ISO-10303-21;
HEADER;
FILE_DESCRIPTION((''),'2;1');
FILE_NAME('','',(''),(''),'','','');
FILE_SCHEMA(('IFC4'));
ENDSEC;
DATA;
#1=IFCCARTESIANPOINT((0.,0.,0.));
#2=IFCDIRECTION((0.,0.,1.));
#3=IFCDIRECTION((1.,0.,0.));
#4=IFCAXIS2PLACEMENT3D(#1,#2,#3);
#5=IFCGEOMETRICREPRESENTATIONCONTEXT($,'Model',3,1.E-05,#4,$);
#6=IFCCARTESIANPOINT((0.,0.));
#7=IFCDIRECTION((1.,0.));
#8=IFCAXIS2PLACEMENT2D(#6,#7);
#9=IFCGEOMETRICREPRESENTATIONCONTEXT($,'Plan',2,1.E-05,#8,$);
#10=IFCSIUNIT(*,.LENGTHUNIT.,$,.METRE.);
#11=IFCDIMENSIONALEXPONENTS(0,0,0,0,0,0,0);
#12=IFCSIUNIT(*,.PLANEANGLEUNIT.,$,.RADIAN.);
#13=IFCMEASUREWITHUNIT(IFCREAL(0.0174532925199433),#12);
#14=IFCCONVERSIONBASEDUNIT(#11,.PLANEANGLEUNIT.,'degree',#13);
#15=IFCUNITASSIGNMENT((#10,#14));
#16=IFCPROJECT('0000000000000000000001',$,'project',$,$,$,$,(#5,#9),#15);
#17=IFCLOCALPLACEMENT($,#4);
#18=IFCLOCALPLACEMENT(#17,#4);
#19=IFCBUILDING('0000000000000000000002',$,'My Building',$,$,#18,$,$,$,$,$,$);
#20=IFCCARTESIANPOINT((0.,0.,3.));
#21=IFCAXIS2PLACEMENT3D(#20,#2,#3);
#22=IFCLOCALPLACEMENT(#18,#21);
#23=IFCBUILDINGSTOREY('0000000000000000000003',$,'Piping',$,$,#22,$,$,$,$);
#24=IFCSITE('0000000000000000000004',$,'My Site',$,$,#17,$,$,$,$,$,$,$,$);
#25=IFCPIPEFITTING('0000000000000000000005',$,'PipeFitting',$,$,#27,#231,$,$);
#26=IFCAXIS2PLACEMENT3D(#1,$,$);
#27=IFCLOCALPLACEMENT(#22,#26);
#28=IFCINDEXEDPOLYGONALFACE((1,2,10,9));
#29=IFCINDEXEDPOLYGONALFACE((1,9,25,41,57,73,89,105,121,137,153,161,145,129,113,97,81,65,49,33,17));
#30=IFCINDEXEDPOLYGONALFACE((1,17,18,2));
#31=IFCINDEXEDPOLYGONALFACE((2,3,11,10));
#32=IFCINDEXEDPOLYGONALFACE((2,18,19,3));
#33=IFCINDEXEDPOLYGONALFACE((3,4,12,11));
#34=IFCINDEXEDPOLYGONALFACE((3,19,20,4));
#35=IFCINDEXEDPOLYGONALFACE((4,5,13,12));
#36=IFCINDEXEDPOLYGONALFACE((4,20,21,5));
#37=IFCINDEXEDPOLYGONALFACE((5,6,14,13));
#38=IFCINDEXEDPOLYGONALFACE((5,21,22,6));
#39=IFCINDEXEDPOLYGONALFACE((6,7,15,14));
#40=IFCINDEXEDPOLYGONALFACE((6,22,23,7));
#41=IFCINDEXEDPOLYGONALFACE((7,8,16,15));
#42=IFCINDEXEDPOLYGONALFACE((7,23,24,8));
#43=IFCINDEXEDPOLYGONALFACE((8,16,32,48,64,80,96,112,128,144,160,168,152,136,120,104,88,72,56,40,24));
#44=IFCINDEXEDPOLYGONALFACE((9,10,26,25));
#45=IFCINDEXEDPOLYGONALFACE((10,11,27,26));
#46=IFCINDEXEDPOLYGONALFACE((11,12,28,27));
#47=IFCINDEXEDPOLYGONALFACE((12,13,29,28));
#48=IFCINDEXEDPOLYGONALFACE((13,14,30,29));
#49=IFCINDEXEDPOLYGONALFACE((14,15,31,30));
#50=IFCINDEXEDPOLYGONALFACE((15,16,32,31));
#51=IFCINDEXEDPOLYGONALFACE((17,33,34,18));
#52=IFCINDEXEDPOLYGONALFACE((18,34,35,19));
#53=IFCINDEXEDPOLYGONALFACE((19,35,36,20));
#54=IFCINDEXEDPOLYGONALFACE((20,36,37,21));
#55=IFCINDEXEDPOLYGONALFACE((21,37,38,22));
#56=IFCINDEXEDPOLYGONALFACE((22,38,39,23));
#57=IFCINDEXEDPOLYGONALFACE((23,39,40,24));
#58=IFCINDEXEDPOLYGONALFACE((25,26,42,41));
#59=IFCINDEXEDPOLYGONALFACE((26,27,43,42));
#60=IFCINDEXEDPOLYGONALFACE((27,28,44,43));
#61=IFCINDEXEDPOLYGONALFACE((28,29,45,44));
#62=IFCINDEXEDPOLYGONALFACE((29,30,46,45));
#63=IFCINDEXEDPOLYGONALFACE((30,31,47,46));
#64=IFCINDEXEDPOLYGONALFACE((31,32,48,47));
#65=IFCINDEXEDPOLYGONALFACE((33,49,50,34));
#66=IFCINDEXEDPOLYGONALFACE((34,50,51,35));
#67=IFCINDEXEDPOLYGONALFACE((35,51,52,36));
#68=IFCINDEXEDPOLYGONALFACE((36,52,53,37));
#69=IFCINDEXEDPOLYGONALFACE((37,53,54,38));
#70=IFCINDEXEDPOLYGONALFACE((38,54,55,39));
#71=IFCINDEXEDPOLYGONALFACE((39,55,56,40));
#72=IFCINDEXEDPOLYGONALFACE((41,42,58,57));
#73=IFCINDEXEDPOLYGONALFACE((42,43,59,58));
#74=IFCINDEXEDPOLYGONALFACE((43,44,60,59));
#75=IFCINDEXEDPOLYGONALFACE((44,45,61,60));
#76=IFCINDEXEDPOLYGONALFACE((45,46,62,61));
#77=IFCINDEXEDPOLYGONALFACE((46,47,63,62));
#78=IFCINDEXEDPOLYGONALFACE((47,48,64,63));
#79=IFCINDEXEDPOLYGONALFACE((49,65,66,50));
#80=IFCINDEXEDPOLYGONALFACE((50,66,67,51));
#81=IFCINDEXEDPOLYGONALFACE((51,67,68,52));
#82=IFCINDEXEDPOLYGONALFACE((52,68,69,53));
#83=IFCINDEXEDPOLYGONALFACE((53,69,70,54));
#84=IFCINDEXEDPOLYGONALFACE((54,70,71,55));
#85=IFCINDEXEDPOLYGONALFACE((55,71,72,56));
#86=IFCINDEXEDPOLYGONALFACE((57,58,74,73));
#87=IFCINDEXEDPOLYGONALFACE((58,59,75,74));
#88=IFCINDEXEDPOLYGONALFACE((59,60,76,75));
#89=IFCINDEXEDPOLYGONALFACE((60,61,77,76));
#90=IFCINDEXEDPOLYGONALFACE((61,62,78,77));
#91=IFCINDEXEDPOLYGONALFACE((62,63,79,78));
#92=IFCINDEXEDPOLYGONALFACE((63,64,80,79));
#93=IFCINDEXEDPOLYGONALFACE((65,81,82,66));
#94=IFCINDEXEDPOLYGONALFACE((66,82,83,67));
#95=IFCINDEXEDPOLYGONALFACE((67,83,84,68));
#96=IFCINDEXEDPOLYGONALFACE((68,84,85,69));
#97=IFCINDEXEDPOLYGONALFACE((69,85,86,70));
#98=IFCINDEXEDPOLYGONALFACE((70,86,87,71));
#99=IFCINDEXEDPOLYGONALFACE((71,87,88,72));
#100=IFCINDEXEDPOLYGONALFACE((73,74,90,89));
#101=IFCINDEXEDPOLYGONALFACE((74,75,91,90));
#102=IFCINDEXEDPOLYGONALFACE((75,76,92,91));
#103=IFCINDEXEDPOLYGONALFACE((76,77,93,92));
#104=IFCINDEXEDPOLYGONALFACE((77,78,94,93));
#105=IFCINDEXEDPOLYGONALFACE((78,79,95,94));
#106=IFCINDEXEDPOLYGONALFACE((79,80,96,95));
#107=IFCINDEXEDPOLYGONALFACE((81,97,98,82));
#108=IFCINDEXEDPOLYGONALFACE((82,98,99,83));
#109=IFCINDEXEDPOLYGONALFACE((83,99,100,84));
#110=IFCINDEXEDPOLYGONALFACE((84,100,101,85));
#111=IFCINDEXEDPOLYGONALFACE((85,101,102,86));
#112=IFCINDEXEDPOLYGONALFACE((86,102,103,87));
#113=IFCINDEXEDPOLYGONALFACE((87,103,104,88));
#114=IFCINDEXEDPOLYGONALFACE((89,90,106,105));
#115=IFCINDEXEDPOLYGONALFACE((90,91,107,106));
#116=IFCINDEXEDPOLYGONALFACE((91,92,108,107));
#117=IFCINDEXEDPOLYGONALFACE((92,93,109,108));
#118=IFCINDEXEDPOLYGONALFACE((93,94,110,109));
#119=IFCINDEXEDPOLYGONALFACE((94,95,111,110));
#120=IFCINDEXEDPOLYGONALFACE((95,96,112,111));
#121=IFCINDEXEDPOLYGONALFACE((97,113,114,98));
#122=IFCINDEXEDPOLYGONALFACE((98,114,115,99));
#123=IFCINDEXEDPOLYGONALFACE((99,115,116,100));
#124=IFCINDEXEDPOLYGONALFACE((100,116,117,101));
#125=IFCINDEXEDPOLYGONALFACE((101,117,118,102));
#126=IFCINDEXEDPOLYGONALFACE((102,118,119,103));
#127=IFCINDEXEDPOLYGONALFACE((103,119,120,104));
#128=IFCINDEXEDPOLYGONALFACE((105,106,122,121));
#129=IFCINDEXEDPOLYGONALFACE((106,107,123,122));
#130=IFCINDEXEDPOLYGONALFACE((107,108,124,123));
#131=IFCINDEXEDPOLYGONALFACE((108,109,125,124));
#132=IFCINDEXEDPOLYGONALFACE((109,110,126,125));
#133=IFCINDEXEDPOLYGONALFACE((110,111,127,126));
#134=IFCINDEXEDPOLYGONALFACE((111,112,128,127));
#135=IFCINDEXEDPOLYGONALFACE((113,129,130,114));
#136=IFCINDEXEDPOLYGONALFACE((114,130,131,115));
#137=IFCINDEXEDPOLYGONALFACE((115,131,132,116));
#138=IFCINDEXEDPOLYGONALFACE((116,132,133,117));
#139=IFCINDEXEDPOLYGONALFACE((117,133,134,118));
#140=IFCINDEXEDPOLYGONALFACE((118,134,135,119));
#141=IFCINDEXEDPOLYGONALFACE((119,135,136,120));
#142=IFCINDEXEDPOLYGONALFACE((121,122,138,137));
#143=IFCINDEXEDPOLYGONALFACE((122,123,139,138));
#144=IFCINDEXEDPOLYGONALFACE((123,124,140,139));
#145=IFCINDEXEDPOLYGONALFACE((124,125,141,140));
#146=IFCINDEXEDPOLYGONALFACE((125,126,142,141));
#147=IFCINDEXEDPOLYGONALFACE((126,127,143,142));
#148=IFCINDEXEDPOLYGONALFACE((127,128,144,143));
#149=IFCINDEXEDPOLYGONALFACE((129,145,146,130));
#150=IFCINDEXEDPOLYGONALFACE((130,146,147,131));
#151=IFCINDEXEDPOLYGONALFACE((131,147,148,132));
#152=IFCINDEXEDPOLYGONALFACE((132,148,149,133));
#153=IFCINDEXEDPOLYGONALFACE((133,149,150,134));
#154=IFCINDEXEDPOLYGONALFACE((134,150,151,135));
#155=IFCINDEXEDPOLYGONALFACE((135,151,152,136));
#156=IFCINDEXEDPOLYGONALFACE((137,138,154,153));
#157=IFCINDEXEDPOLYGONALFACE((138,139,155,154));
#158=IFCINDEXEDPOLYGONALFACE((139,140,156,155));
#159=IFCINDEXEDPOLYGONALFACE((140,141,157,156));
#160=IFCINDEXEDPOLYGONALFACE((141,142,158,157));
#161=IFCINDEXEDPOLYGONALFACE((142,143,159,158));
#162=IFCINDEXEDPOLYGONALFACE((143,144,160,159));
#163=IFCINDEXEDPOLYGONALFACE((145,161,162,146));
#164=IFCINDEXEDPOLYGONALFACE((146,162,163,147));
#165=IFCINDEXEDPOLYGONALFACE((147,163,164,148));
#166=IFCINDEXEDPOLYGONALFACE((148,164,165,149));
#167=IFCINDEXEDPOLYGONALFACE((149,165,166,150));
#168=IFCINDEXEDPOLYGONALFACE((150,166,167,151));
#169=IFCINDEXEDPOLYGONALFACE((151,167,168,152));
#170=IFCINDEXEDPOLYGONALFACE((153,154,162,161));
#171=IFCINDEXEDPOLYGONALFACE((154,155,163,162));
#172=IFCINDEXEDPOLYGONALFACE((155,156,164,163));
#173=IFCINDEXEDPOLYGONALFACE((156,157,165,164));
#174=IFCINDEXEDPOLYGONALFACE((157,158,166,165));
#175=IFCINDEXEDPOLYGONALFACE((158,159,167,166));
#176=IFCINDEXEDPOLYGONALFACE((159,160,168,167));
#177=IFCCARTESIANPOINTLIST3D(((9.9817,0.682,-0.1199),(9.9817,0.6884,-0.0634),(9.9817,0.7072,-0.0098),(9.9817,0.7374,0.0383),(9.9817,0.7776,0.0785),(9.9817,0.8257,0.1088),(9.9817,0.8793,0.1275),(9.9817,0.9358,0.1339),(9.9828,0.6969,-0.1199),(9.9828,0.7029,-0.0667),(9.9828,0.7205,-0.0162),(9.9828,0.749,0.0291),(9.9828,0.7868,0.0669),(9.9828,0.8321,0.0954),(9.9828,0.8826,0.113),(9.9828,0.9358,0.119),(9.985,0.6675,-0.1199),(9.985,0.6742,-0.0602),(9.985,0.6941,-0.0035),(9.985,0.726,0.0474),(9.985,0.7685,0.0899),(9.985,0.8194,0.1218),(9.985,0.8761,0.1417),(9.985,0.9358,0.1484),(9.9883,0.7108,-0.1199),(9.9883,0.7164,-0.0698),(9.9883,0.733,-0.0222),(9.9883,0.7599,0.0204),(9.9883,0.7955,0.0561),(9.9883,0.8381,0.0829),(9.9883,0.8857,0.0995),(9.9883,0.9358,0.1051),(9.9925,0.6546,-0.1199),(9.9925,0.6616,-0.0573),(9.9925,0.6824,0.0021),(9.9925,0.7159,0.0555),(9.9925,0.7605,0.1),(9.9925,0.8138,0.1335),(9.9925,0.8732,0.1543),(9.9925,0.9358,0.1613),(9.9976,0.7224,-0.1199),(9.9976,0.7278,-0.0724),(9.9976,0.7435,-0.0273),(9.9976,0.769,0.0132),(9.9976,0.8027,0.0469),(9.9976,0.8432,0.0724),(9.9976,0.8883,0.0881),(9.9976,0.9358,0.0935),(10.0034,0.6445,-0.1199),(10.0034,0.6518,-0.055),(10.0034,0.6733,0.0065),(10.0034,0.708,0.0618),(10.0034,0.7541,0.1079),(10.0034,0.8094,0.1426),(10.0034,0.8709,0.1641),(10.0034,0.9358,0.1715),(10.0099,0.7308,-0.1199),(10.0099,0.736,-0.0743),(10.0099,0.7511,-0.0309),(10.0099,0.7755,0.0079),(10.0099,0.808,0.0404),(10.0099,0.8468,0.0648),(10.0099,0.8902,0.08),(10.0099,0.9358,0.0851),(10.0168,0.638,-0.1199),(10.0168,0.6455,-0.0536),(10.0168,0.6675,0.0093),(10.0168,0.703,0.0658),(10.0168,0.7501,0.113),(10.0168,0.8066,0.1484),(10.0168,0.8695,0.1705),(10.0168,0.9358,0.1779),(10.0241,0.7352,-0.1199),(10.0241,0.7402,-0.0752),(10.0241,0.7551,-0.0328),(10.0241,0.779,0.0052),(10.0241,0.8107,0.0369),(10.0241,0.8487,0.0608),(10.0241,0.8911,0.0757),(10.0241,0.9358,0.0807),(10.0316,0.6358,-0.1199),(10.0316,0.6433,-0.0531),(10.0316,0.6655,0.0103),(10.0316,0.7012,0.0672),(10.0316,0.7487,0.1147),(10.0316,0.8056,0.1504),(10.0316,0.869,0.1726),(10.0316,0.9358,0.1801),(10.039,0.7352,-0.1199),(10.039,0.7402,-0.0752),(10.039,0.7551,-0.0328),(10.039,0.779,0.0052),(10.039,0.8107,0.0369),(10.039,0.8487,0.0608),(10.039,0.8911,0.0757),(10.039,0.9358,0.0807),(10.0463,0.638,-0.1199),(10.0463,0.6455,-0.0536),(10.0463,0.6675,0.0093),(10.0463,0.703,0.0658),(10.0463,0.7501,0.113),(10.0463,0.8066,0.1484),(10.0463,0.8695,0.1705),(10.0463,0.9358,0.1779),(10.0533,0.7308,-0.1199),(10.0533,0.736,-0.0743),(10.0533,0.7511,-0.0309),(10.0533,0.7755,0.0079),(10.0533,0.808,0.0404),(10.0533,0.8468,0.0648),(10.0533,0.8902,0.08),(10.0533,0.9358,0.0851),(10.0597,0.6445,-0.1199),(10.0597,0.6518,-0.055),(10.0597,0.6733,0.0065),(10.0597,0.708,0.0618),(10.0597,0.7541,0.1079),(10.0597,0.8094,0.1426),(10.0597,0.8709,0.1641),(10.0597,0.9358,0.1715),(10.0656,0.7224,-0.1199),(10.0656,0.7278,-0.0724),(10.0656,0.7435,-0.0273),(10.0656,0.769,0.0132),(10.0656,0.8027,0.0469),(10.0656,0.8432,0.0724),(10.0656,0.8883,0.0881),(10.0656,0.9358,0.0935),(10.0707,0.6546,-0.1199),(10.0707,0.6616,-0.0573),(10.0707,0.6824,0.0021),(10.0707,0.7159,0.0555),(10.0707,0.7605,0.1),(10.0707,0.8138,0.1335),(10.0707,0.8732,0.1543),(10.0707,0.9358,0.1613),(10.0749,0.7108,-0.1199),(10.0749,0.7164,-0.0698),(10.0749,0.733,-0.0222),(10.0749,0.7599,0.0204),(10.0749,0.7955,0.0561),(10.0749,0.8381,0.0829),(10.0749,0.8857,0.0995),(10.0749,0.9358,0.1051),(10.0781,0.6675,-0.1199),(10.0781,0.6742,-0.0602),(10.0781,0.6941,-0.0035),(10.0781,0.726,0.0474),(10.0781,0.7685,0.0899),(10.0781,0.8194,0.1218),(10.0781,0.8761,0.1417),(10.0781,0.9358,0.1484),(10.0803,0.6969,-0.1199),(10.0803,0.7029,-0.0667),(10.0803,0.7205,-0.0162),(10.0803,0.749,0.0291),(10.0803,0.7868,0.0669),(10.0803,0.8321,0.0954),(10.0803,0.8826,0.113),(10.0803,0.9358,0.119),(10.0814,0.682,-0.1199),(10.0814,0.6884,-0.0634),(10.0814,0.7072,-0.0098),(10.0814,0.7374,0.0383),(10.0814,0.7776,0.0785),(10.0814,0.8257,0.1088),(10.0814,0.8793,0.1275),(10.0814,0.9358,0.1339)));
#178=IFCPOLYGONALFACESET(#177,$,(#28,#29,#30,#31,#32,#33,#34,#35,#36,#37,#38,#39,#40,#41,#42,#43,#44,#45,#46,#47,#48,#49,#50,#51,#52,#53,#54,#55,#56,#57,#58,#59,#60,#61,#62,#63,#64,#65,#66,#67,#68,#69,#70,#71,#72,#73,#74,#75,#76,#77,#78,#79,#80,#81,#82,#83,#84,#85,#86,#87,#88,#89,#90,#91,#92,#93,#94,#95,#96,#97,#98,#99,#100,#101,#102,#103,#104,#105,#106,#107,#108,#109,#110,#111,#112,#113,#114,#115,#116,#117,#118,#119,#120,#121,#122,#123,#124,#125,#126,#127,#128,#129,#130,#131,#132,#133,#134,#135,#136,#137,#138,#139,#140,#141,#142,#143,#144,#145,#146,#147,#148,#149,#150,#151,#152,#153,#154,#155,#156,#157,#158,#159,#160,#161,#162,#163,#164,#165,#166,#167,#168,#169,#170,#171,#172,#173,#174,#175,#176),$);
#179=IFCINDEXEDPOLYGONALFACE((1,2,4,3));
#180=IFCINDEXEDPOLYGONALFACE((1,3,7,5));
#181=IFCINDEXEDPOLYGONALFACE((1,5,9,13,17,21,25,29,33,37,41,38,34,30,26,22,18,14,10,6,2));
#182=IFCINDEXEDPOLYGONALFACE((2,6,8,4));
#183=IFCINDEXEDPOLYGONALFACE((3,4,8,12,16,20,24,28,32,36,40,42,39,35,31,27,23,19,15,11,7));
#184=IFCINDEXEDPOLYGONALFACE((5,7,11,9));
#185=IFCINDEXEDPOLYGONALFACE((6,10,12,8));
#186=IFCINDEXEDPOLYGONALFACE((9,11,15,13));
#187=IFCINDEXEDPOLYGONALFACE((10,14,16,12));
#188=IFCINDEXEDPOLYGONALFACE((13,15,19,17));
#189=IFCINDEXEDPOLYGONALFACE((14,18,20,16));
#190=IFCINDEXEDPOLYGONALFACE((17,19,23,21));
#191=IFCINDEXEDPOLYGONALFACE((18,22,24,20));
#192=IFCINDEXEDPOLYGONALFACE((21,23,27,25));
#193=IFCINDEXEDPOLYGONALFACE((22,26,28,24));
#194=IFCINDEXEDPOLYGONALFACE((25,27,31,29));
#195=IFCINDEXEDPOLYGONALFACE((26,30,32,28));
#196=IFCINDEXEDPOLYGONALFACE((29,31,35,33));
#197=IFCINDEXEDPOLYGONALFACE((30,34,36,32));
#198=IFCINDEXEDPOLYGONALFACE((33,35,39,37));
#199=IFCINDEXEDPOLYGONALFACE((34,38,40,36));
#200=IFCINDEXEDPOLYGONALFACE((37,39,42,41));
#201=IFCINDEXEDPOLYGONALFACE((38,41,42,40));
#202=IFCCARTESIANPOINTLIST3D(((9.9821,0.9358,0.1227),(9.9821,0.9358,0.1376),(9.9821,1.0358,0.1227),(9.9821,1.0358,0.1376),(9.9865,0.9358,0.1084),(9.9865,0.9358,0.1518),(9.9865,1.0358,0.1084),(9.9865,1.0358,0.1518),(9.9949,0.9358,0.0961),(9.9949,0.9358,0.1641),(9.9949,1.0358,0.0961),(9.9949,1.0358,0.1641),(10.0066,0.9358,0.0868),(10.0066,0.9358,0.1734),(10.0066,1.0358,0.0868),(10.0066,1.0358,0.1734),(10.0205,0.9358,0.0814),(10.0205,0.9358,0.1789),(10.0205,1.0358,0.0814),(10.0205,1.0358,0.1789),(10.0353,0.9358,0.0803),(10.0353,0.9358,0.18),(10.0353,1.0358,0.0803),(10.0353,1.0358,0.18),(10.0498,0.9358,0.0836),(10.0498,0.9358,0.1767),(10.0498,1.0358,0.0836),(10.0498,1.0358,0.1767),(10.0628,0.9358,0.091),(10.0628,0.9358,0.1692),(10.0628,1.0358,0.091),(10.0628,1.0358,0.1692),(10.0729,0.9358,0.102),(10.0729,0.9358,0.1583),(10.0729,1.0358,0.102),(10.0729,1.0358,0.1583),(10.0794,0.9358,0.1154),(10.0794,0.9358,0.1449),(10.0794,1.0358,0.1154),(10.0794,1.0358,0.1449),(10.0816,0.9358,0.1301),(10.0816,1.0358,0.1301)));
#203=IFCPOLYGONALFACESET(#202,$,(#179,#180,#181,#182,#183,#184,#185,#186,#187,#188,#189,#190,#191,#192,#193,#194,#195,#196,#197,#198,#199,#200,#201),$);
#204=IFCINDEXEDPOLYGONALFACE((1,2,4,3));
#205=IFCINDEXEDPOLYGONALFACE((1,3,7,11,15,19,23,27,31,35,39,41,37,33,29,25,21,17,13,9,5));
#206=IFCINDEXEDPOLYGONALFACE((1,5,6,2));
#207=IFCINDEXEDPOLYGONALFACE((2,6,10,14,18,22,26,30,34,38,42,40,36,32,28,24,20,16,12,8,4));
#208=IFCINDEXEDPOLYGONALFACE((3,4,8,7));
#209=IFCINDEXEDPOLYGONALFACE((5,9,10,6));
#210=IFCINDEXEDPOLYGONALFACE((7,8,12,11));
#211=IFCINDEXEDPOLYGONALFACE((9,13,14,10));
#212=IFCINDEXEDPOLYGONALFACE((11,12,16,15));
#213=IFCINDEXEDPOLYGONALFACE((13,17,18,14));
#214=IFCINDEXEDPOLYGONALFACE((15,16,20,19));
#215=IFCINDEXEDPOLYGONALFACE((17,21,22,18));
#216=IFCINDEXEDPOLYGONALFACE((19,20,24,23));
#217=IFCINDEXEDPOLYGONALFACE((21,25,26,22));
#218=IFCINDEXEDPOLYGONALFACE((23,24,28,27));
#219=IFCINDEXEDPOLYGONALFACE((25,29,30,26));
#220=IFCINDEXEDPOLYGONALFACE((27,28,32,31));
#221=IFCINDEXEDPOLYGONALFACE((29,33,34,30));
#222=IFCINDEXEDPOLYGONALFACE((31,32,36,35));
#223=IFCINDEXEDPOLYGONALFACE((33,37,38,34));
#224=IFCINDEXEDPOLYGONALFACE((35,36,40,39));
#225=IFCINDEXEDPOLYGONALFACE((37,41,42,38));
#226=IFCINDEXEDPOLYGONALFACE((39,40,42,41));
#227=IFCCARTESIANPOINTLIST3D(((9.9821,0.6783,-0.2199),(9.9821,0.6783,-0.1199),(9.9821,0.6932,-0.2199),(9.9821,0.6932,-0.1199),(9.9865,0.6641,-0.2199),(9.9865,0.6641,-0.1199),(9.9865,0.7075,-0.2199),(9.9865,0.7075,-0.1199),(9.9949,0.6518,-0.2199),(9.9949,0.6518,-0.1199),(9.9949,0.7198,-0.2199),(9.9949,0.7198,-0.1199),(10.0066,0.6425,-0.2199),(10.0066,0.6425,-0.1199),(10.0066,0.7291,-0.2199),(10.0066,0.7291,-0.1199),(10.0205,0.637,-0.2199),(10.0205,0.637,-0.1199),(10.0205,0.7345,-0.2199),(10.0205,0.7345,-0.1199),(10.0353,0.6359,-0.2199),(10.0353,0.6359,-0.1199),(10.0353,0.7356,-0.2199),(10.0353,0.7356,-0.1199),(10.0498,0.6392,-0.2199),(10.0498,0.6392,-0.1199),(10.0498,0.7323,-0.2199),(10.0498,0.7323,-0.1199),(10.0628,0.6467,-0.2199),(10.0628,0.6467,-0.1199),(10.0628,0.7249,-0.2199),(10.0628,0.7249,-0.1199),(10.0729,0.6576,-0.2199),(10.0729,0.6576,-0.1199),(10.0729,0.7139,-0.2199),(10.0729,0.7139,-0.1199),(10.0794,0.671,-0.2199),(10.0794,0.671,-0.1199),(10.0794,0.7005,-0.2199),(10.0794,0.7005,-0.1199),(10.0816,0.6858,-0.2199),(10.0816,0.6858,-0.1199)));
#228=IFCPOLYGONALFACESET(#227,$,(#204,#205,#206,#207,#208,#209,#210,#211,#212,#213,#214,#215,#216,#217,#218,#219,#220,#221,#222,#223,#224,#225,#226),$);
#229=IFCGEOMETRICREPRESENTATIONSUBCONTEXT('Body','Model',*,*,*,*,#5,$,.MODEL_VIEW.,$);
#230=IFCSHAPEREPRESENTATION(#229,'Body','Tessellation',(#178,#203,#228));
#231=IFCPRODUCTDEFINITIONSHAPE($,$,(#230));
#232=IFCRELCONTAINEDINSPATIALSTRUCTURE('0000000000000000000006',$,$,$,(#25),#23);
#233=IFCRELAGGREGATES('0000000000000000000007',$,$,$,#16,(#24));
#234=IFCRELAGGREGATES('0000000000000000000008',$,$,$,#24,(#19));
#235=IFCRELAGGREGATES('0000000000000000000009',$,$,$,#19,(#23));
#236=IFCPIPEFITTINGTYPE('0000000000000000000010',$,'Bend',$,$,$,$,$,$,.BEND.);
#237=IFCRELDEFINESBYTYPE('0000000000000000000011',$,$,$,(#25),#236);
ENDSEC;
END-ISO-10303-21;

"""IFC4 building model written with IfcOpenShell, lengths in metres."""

from ifc_helpers import new_model, entity, si_unit, converted_unit, frame, origin_with_axes, origin_2d_with_axis, place, context, subcontext, project, spatial, circle, extrude, source, transform, mapped, type_object, type_shapes, element, save


model = new_model("IFC4")

# Units and contexts
model_context = context("Model", 3, precision=1e-05, world=origin_with_axes())
plan_context = context("Plan", 2, precision=1e-05, world=origin_2d_with_axis())
body_context = subcontext(model_context, "Body", "Model", "MODEL_VIEW")
ifc_project = project(units=[si_unit("LENGTHUNIT", "METRE"), converted_unit("PLANEANGLEUNIT", "degree", entity("IfcReal", 0.0174532925199433), si_unit("PLANEANGLEUNIT", "RADIAN"), dimensions=[0, 0, 0, 0, 0, 0, 0])], contexts=[model_context, plan_context])

# Site, building, storey
site_placement = place(None, origin_with_axes())
site = spatial("IfcSite", under=ifc_project, at=site_placement, Name="My Site")
building_placement = place(site_placement, origin_with_axes())
building = spatial("IfcBuilding", under=site, at=building_placement, Name="My Building")
storey_placement = place(building_placement, frame((0.0, 0.0, 3.0), z_axis=(0.0, 0.0, 1.0), x_axis=(1.0, 0.0, 0.0)))
storey = spatial("IfcBuildingStorey", under=building, at=storey_placement, Name="Piping")

# Pipe fitting
pipe_fitting_type_1 = type_object("IfcPipeFittingType", Name="Bend", PredefinedType="BEND")
shared_shape_1 = source(origin_with_axes(), body_context, "Body", "SolidModel", [
    entity("IfcSweptDiskSolid", entity("IfcIndexedPolyCurve", entity("IfcCartesianPointList3D", [[0.0, 0.0, 0.1], [0.0, -0.0732, 0.2768], [0.0, -0.25, 0.35]]), [entity("IfcArcIndex", [1, 2, 3])]), 0.05),
    extrude(circle(Radius=0.05), origin_with_axes(), (0.0, 0.0, 1.0), 0.1),
    extrude(circle(Radius=0.05), frame((0.0, -0.25, 0.35), z_axis=(0.0, -1.0, -0.000015), x_axis=(1.0, 0.0, 0.0)), (0.0, 0.0, 1.0), 0.1),
])
type_shapes(pipe_fitting_type_1, [shared_shape_1])
for number, where, z_axis, x_axis, name in (
    (1, (10.0316, 1.0358, 0.1301), (0.0, -1.0, 0.000015), (1.0, 0.0, 0.0), "PipeFitting"),
):
    element("IfcPipeFitting", number, at=place(storey_placement, frame(where, z_axis=z_axis, x_axis=x_axis)), inside=storey, type_object=pipe_fitting_type_1, Name=name, context=body_context, shape_type="MappedRepresentation", body=[
        mapped(shared_shape_1, transform((0.0, 0.0, 0.0), x_axis=(1.0, 0.0, 0.0), y_axis=(0.0, 1.0, 0.0), z_axis=(0.0, 0.0, 1.0), scale=1.0)),
    ])

save(model, "model.ifc")
